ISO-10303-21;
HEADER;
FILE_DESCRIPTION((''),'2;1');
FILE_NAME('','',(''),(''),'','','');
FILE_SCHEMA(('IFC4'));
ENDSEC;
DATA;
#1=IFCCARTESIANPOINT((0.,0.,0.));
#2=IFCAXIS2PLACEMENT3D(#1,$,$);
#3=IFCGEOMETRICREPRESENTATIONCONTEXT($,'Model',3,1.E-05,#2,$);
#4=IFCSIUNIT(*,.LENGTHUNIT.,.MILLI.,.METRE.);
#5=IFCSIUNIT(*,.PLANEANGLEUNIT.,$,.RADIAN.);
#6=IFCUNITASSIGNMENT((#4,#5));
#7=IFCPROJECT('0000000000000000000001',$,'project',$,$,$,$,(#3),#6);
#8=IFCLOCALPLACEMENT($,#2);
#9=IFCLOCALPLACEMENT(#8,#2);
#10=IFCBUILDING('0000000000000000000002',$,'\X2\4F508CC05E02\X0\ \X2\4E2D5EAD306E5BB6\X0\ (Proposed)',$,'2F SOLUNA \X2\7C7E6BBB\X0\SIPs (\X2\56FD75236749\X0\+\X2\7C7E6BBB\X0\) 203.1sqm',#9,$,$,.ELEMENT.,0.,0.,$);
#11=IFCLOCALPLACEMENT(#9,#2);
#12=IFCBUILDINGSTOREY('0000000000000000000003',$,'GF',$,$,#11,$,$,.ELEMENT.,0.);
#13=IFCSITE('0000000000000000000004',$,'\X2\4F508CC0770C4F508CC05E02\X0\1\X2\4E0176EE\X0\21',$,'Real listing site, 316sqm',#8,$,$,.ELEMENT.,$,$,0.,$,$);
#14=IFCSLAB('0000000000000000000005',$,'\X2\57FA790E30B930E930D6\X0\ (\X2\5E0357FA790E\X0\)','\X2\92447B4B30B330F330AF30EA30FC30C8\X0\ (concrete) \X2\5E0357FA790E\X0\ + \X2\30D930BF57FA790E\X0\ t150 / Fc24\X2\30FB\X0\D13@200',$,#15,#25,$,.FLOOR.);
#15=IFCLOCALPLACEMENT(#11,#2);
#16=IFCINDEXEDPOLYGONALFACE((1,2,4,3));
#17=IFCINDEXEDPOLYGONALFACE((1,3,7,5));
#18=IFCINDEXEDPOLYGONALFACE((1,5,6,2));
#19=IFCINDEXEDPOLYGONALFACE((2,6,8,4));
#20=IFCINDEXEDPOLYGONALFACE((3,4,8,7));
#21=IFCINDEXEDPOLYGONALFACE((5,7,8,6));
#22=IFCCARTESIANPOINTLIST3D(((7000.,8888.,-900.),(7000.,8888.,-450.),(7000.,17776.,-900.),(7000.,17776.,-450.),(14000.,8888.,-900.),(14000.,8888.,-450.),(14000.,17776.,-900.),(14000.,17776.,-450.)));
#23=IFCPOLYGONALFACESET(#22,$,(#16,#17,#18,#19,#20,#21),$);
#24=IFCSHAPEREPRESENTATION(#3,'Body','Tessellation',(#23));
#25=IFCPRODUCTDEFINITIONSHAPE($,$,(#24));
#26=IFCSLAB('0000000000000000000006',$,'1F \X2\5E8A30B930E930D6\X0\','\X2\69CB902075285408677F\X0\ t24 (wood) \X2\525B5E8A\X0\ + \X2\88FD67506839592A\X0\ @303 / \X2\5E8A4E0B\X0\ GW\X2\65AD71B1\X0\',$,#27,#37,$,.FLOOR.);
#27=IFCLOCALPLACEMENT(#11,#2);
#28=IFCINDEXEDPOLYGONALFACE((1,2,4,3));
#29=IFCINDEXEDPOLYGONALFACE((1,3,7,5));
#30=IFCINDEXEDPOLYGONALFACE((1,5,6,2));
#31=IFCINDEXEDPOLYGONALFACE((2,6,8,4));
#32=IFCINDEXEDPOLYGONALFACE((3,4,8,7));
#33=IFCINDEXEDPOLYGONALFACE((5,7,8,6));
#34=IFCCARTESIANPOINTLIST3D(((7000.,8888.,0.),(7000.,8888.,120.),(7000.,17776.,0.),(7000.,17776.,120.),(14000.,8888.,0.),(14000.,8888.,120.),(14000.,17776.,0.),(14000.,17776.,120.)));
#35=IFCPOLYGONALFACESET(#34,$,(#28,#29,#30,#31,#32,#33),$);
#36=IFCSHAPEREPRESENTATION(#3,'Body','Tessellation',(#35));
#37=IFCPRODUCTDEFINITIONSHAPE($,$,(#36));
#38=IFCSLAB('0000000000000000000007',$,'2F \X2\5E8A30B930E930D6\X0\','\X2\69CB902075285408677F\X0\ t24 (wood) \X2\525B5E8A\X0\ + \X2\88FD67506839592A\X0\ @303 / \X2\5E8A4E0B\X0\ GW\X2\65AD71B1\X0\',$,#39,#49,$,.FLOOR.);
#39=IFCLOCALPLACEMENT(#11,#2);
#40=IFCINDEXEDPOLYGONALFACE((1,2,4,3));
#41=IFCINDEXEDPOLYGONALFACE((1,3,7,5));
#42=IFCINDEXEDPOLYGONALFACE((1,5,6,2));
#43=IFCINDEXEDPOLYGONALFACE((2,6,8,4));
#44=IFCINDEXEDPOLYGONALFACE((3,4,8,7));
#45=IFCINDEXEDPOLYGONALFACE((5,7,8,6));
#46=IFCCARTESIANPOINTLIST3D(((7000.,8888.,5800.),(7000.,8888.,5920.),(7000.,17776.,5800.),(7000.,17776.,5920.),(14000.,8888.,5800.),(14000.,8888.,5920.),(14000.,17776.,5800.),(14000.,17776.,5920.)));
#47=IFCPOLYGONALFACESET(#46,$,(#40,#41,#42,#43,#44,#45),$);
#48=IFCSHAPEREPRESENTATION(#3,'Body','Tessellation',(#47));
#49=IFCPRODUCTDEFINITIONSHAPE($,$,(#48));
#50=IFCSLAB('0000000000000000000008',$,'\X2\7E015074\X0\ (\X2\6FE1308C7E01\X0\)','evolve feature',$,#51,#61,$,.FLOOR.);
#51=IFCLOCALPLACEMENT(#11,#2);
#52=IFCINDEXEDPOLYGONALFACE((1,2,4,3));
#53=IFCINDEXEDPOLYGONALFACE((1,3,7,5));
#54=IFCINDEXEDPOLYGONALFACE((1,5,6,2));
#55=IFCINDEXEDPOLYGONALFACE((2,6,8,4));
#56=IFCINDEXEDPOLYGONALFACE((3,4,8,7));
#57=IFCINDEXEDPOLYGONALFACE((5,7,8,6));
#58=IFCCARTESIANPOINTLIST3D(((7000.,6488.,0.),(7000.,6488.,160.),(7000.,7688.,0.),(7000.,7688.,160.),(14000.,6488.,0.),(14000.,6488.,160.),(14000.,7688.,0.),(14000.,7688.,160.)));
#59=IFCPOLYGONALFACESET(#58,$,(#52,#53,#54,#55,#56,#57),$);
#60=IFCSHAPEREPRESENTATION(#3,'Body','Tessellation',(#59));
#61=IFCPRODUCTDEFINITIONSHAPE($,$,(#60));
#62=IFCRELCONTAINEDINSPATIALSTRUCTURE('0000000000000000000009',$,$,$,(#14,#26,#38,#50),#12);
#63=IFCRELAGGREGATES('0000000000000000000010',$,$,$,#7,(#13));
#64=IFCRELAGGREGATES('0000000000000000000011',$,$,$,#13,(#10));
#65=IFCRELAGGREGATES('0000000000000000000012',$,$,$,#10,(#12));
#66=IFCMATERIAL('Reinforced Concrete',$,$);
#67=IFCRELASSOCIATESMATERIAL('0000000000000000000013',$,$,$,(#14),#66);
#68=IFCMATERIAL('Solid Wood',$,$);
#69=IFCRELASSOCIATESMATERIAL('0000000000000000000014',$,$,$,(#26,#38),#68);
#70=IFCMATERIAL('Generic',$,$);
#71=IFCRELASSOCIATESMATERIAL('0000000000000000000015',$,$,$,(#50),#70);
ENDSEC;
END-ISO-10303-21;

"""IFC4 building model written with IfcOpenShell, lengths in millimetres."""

from ifc_helpers import new_model, si_unit, frame, frame_2d, origin, place, context, project, spatial, rectangle, extrude, material, element, save


model = new_model("IFC4")

# Units and contexts
model_context = context("Model", 3, precision=1e-05, world=origin())
ifc_project = project(units=[si_unit("LENGTHUNIT", "METRE", prefix="MILLI"), si_unit("PLANEANGLEUNIT", "RADIAN")], contexts=[model_context])

# Site, building, storey
site_placement = place(None, origin())
site = spatial("IfcSite", under=ifc_project, at=site_placement, Name="佐賀県佐賀市1丁目21", ObjectType="Real listing site, 316sqm", CompositionType="ELEMENT", RefElevation=0.0)
building_placement = place(site_placement, origin())
building = spatial("IfcBuilding", under=site, at=building_placement, Name="佐賀市 中庭の家 (Proposed)", ObjectType="2F SOLUNA 籾殻SIPs (国産杉+籾殻) 203.1sqm", CompositionType="ELEMENT", ElevationOfRefHeight=0.0, ElevationOfTerrain=0.0)
storey_placement = place(building_placement, origin())
storey = spatial("IfcBuildingStorey", under=building, at=storey_placement, Name="GF", CompositionType="ELEMENT", Elevation=0.0)

# Slabs
ifc_material_1 = material(Name="Reinforced Concrete")
slab_1_placement = place(storey_placement, frame((3500.0, 4444.0, -450.0)))
element("IfcSlab", 1, at=slab_1_placement, inside=storey, material=ifc_material_1, Name="基礎スラブ (布基礎)", Description="鉄筋コンクリート (concrete) 布基礎 + ベタ基礎 t150 / Fc24・D13@200", PredefinedType="FLOOR", context=model_context, shape_type="SweptSolid", body=[
    extrude(rectangle(XDim=7000.0, YDim=8888.0, at=frame_2d((3500.0, 4444.0))), frame((3500.0, 4444.0, -450.0)), (0.0, 0.0, 1.0), 450.0),
])
ifc_material_2 = material(Name="Solid Wood")
slab_2_placement = place(storey_placement, frame((3500.0, 4444.0, 0.0)))
element("IfcSlab", 2, at=slab_2_placement, inside=storey, material=ifc_material_2, Name="1F 床スラブ", Description="構造用合板 t24 (wood) 剛床 + 製材根太 @303 / 床下 GW断熱", PredefinedType="FLOOR", context=model_context, shape_type="SweptSolid", body=[
    extrude(rectangle(XDim=7000.0, YDim=8888.0, at=frame_2d((3500.0, 4444.0))), frame((3500.0, 4444.0, 0.0)), (0.0, 0.0, 1.0), 120.0),
])
slab_3_placement = place(storey_placement, frame((3500.0, 4444.0, 2900.0)))
element("IfcSlab", 3, at=slab_3_placement, inside=storey, material=ifc_material_2, Name="2F 床スラブ", Description="構造用合板 t24 (wood) 剛床 + 製材根太 @303 / 床下 GW断熱", PredefinedType="FLOOR", context=model_context, shape_type="SweptSolid", body=[
    extrude(rectangle(XDim=7000.0, YDim=8888.0, at=frame_2d((3500.0, 4444.0))), frame((3500.0, 4444.0, 2900.0)), (0.0, 0.0, 1.0), 120.0),
])
ifc_material_3 = material(Name="Generic")
slab_4_placement = place(storey_placement, frame((3500.0, 3244.0, 0.0)))
element("IfcSlab", 4, at=slab_4_placement, inside=storey, material=ifc_material_3, Name="縁側 (濡れ縁)", Description="evolve feature", PredefinedType="FLOOR", context=model_context, shape_type="SweptSolid", body=[
    extrude(rectangle(XDim=7000.0, YDim=1200.0, at=frame_2d((3500.0, 600.0))), frame((3500.0, 3244.0, 0.0)), (0.0, 0.0, 1.0), 160.0),
])

save(model, "model.ifc")
